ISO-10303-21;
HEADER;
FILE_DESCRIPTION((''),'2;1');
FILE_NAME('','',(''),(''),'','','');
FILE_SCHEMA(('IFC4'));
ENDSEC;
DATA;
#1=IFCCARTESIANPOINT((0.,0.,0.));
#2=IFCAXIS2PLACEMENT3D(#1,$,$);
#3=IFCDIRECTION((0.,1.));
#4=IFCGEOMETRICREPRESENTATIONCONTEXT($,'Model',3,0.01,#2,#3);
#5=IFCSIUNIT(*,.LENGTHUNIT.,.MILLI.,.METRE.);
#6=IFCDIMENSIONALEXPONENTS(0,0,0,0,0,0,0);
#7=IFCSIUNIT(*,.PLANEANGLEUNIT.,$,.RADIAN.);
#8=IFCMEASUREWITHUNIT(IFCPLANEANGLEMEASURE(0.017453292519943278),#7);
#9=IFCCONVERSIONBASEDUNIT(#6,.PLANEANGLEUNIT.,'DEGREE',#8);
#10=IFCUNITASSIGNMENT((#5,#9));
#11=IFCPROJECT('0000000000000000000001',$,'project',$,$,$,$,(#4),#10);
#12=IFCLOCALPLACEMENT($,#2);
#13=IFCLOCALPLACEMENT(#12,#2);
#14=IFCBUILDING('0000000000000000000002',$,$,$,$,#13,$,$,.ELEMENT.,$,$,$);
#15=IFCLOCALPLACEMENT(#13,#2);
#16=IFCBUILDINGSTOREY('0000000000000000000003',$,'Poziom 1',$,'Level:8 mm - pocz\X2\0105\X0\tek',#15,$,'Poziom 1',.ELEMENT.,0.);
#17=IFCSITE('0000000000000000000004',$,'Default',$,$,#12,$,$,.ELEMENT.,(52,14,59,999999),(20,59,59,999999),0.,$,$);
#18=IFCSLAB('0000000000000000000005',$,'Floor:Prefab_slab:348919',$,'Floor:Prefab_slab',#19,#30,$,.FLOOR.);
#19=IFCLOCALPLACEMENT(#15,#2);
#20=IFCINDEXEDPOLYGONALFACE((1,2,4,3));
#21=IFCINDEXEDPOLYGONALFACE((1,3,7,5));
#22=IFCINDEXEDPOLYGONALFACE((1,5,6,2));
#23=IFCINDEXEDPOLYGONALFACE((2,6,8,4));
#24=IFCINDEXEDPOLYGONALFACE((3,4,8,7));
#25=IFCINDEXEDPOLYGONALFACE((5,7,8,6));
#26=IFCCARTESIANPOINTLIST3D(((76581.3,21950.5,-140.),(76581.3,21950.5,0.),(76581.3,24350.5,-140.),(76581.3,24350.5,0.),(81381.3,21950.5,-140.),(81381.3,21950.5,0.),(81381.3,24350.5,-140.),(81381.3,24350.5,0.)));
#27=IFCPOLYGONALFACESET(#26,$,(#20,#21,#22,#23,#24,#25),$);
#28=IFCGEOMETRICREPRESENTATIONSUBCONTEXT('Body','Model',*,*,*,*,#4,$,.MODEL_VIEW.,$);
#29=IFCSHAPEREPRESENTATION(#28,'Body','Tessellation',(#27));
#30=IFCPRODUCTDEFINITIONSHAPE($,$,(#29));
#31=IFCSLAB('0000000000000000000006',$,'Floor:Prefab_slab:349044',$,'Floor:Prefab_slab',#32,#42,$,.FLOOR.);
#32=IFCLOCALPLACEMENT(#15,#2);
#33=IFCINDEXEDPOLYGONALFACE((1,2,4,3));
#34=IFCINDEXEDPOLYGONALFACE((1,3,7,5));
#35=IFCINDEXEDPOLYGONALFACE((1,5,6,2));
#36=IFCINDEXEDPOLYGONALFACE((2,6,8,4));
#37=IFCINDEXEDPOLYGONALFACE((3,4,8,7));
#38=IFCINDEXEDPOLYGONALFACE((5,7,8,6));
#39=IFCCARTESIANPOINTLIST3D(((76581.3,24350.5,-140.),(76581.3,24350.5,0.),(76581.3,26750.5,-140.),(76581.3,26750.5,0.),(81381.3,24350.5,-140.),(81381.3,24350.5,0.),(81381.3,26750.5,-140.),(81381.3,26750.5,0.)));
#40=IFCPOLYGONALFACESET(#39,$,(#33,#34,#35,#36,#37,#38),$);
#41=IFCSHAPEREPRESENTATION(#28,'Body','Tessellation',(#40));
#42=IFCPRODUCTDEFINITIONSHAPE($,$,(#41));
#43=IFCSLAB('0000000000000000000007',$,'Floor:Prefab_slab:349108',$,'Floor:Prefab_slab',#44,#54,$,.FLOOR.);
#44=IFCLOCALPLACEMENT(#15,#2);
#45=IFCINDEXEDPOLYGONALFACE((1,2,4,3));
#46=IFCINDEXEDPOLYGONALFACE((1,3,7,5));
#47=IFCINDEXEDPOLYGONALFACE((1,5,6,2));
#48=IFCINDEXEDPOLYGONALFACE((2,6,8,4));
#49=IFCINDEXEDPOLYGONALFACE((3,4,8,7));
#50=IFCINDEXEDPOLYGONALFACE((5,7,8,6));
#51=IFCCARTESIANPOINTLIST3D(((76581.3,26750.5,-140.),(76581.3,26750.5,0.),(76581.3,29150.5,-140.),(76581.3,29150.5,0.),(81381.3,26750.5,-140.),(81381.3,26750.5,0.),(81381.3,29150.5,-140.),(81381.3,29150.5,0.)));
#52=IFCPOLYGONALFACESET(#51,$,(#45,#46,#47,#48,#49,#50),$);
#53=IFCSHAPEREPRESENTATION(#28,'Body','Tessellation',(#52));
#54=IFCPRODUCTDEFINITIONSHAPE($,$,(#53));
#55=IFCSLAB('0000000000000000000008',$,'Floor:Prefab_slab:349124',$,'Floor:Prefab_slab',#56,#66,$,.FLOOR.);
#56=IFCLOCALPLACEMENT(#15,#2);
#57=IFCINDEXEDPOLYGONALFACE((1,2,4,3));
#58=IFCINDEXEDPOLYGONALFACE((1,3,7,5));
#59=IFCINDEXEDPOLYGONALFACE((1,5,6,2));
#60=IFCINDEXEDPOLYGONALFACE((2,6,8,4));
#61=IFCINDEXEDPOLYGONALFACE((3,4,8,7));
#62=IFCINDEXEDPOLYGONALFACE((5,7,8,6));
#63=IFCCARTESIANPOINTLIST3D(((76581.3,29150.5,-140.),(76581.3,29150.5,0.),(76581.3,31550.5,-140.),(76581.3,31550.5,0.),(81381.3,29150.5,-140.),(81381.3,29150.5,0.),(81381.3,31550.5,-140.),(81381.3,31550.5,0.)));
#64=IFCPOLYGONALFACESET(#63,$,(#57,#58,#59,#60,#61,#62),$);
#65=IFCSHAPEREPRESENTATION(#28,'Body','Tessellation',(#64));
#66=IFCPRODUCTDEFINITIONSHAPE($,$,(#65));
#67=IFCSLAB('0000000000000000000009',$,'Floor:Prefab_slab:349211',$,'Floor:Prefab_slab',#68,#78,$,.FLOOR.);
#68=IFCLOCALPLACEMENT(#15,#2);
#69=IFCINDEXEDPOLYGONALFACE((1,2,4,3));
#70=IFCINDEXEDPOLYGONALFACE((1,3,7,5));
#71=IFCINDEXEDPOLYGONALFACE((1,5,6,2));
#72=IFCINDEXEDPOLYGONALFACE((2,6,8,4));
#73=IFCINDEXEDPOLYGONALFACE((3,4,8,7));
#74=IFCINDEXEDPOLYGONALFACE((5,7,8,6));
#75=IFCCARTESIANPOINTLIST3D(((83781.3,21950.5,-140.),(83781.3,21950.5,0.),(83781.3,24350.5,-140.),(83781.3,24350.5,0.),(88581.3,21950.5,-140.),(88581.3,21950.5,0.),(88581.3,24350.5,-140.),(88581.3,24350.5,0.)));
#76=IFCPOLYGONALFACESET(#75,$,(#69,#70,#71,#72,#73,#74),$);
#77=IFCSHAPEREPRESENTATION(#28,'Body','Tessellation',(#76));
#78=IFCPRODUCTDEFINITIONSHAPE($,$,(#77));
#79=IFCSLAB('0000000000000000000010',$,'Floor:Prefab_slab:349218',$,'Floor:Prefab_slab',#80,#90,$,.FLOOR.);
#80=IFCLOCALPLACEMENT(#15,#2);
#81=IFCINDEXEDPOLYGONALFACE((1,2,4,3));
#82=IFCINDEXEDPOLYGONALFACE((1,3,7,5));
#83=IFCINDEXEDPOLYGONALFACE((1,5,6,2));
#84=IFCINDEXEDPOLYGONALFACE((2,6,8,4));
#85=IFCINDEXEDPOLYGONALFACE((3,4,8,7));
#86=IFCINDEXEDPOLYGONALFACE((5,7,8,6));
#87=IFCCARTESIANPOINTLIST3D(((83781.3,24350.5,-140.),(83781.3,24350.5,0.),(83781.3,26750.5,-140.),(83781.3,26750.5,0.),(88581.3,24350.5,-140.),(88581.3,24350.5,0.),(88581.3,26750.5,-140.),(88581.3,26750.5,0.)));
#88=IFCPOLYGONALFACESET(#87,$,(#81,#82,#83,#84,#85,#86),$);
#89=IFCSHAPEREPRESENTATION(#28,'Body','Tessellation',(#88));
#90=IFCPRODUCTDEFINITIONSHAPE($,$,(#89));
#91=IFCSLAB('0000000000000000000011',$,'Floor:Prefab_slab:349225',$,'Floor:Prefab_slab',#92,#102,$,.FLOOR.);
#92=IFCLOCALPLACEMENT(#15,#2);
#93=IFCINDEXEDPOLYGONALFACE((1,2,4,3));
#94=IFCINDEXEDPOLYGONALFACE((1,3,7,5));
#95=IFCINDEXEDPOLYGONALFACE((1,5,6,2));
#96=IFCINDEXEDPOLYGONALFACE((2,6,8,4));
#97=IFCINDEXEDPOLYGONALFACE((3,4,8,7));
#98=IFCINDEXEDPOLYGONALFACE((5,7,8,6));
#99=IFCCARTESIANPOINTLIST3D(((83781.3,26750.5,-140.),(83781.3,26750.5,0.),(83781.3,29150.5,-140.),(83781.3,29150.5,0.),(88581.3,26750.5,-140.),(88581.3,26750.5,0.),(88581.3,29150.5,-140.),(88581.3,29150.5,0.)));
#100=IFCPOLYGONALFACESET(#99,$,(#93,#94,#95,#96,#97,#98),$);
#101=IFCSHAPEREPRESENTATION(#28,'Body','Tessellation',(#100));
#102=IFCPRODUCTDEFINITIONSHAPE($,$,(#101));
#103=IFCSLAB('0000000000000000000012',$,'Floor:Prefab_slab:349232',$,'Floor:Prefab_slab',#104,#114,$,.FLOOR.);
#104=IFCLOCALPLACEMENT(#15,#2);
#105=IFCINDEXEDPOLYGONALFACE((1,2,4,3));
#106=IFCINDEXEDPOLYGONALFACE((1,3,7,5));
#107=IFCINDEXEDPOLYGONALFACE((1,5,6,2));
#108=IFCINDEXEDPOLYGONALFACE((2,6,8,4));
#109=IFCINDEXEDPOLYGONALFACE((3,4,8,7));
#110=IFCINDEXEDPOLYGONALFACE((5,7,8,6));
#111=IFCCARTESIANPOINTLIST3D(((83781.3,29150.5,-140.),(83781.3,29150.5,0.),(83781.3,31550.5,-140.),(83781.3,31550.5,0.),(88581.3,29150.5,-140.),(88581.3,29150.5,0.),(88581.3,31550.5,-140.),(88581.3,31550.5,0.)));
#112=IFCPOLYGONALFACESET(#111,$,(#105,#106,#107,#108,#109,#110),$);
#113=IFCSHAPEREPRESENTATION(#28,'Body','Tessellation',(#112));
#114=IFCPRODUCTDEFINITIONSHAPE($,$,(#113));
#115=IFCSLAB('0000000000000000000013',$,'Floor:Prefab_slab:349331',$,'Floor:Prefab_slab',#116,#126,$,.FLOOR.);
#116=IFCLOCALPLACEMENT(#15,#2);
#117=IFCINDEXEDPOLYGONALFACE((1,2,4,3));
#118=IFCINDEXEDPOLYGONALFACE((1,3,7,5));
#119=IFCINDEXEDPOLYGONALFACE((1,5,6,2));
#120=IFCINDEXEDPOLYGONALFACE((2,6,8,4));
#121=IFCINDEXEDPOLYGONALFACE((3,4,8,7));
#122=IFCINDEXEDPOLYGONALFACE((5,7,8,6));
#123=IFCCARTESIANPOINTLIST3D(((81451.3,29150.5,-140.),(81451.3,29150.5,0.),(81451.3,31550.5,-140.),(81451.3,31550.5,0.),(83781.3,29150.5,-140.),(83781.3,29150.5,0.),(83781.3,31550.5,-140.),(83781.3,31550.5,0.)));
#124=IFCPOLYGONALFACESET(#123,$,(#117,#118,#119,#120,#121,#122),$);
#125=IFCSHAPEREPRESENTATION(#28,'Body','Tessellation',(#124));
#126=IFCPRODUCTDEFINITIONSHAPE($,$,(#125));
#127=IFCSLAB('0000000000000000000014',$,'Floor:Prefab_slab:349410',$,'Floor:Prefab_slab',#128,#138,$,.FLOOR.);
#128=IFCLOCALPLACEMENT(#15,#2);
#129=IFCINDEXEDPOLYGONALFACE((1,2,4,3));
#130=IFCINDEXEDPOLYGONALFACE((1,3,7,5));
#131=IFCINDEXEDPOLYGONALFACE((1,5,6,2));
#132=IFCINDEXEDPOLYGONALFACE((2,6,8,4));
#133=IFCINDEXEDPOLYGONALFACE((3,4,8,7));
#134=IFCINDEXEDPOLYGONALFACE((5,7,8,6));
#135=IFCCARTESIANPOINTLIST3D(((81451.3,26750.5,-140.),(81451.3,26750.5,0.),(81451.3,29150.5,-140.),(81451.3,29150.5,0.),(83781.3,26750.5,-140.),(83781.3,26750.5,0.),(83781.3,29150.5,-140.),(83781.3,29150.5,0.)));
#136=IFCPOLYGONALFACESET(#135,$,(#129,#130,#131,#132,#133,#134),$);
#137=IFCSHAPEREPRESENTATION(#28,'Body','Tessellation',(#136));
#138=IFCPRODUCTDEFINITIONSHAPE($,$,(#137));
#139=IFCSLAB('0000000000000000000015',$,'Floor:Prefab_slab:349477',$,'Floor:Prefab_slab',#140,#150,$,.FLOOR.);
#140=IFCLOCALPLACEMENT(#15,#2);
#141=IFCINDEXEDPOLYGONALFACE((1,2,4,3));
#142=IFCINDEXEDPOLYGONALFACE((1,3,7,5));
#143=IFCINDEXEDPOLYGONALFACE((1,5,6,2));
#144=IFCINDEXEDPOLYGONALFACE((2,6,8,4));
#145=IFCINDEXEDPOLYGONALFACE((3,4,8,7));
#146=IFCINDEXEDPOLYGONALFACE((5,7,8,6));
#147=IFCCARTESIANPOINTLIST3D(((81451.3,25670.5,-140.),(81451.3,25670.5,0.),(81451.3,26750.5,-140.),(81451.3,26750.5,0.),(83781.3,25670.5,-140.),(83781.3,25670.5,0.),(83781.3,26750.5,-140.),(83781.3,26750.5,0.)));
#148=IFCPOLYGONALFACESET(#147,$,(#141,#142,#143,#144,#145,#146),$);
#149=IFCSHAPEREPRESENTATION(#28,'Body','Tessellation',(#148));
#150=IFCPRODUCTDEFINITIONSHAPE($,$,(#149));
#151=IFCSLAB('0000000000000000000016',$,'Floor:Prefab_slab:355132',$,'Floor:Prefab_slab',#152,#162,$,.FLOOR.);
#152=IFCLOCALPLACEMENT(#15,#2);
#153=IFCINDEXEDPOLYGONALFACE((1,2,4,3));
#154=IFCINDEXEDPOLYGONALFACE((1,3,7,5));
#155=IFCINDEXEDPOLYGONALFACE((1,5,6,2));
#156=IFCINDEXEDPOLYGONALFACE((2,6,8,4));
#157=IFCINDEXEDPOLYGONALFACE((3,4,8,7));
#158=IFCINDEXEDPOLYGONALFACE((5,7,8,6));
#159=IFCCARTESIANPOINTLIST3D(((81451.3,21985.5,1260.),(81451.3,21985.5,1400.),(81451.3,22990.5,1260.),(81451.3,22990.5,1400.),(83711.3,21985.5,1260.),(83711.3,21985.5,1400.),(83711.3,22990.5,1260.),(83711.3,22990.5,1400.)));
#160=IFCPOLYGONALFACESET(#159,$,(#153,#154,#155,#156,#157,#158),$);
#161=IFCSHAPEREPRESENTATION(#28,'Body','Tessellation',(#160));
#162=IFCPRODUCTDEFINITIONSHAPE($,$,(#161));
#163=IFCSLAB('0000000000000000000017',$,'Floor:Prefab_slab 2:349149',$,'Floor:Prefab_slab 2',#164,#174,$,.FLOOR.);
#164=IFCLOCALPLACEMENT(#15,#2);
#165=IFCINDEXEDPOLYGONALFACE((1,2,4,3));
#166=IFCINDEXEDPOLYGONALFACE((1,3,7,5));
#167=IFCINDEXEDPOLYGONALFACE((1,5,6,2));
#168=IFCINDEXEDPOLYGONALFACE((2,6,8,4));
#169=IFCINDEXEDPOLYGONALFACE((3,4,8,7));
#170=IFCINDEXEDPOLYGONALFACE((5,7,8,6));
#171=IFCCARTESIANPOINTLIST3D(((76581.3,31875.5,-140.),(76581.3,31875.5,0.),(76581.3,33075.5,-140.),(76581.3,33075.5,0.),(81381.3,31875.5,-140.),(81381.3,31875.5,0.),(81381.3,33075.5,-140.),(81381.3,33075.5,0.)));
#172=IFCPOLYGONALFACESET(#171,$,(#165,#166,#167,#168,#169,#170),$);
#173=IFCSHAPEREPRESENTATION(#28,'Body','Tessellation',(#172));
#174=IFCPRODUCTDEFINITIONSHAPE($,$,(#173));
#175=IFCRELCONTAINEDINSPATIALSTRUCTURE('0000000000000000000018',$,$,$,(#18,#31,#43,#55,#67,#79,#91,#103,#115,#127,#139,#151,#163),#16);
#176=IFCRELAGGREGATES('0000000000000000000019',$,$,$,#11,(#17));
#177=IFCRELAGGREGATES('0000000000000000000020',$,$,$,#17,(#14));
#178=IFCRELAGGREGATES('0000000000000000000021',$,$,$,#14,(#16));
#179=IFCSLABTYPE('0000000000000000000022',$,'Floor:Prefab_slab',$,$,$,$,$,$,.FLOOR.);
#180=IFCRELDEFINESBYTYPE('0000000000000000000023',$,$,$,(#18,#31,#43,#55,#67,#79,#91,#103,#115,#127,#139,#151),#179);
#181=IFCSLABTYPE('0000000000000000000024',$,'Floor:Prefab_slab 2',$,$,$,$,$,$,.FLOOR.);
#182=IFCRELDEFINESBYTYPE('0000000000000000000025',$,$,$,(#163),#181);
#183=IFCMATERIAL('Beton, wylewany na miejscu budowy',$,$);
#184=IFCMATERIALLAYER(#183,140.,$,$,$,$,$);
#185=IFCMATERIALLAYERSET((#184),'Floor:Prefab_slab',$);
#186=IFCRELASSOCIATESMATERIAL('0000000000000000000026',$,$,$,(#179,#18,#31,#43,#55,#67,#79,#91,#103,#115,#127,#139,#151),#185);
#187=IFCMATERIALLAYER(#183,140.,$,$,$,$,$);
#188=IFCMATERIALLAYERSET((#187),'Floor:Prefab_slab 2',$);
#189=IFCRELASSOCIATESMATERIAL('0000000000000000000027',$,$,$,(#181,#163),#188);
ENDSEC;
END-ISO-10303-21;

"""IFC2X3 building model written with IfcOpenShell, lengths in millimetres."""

from ifc_helpers import new_model, entity, si_unit, converted_unit, direction, frame, frame_2d, origin, origin_2d_with_axis, place, context, subcontext, project, spatial, rectangle, extrude, material, layer, layer_set, layer_usage, type_object, element, save


model = new_model("IFC2X3")

# Units and contexts
model_context = context("Model", 3, precision=0.01, world=origin(), true_north=direction((0.0, 1.0)))
body_context = subcontext(model_context, "Body", "Model", "MODEL_VIEW")
ifc_project = project(units=[si_unit("LENGTHUNIT", "METRE", prefix="MILLI"), converted_unit("PLANEANGLEUNIT", "DEGREE", entity("IfcPlaneAngleMeasure", 0.017453292519943278), si_unit("PLANEANGLEUNIT", "RADIAN"), dimensions=[0, 0, 0, 0, 0, 0, 0])], contexts=[model_context])

# Site, building, storey
site_placement = place(None, origin())
site = spatial("IfcSite", under=ifc_project, at=site_placement, Name="Default", CompositionType="ELEMENT", RefLatitude=(52, 14, 59, 999999), RefLongitude=(20, 59, 59, 999999), RefElevation=0.0)
building_placement = place(site_placement, origin())
building = spatial("IfcBuilding", under=site, at=building_placement, CompositionType="ELEMENT")
storey_placement = place(building_placement, origin())
storey = spatial("IfcBuildingStorey", under=building, at=storey_placement, Name="Poziom 1", ObjectType="Level:8 mm - początek", LongName="Poziom 1", CompositionType="ELEMENT", Elevation=0.0)

# Slabs
ifc_material_1 = material(Name="Beton, wylewany na miejscu budowy")
ifc_layer_1 = layer(ifc_material_1, 140.0)
ifc_layer_set_1 = layer_set([ifc_layer_1], Name="Floor:Prefab_slab")
ifc_layer_usage_1 = layer_usage(ifc_layer_set_1, "AXIS3", "POSITIVE", 0.0)
slab_type_1 = type_object("IfcSlabType", Name="Floor:Prefab_slab", PredefinedType="FLOOR", material=ifc_layer_set_1)
slab_1_placement = place(storey_placement, origin())
element("IfcSlab", 1, at=slab_1_placement, inside=storey, type_object=slab_type_1, material=ifc_layer_usage_1, Name="Floor:Prefab_slab:348919", ObjectType="Floor:Prefab_slab", PredefinedType="FLOOR", context=body_context, shape_type="SweptSolid", body=[
    extrude(rectangle(XDim=2400.0, YDim=4800.0, at=frame_2d((0.0, 0.0), x_axis=(1.0, 0.0))), frame((78981.3, 23150.5, 0.0), z_axis=(0.0, 0.0, -1.0), x_axis=(0.0, 1.0, 0.0)), (0.0, 0.0, 1.0), 140.0),
])
ifc_layer_usage_2 = layer_usage(ifc_layer_set_1, "AXIS3", "POSITIVE", 0.0)
slab_2_placement = place(storey_placement, origin())
element("IfcSlab", 2, at=slab_2_placement, inside=storey, type_object=slab_type_1, material=ifc_layer_usage_2, Name="Floor:Prefab_slab:349044", ObjectType="Floor:Prefab_slab", PredefinedType="FLOOR", context=body_context, shape_type="SweptSolid", body=[
    extrude(rectangle(XDim=2400.0, YDim=4800.0, at=frame_2d((0.0, 0.0), x_axis=(1.0, 0.0))), frame((78981.3, 25550.5, 0.0), z_axis=(0.0, 0.0, -1.0), x_axis=(0.0, 1.0, 0.0)), (0.0, 0.0, 1.0), 140.0),
])
ifc_layer_usage_3 = layer_usage(ifc_layer_set_1, "AXIS3", "POSITIVE", 0.0)
slab_3_placement = place(storey_placement, origin())
element("IfcSlab", 3, at=slab_3_placement, inside=storey, type_object=slab_type_1, material=ifc_layer_usage_3, Name="Floor:Prefab_slab:349108", ObjectType="Floor:Prefab_slab", PredefinedType="FLOOR", context=body_context, shape_type="SweptSolid", body=[
    extrude(rectangle(XDim=2400.0, YDim=4800.0, at=frame_2d((0.0, 0.0), x_axis=(1.0, 0.0))), frame((78981.3, 27950.5, 0.0), z_axis=(0.0, 0.0, -1.0), x_axis=(0.0, 1.0, 0.0)), (0.0, 0.0, 1.0), 140.0),
])
ifc_layer_usage_4 = layer_usage(ifc_layer_set_1, "AXIS3", "POSITIVE", 0.0)
slab_4_placement = place(storey_placement, origin())
element("IfcSlab", 4, at=slab_4_placement, inside=storey, type_object=slab_type_1, material=ifc_layer_usage_4, Name="Floor:Prefab_slab:349124", ObjectType="Floor:Prefab_slab", PredefinedType="FLOOR", context=body_context, shape_type="SweptSolid", body=[
    extrude(rectangle(XDim=2400.0, YDim=4800.0, at=frame_2d((0.0, 0.0), x_axis=(1.0, 0.0))), frame((78981.3, 30350.5, 0.0), z_axis=(0.0, 0.0, -1.0), x_axis=(0.0, 1.0, 0.0)), (0.0, 0.0, 1.0), 140.0),
])
ifc_layer_usage_5 = layer_usage(ifc_layer_set_1, "AXIS3", "POSITIVE", 0.0)
slab_5_placement = place(storey_placement, origin())
element("IfcSlab", 5, at=slab_5_placement, inside=storey, type_object=slab_type_1, material=ifc_layer_usage_5, Name="Floor:Prefab_slab:349211", ObjectType="Floor:Prefab_slab", PredefinedType="FLOOR", context=body_context, shape_type="SweptSolid", body=[
    extrude(rectangle(XDim=2400.0, YDim=4800.0, at=frame_2d((0.0, 0.0), x_axis=(1.0, 0.0))), frame((86181.3, 23150.5, 0.0), z_axis=(0.0, 0.0, -1.0), x_axis=(0.0, 1.0, 0.0)), (0.0, 0.0, 1.0), 140.0),
])
ifc_layer_usage_6 = layer_usage(ifc_layer_set_1, "AXIS3", "POSITIVE", 0.0)
slab_6_placement = place(storey_placement, origin())
element("IfcSlab", 6, at=slab_6_placement, inside=storey, type_object=slab_type_1, material=ifc_layer_usage_6, Name="Floor:Prefab_slab:349218", ObjectType="Floor:Prefab_slab", PredefinedType="FLOOR", context=body_context, shape_type="SweptSolid", body=[
    extrude(rectangle(XDim=2400.0, YDim=4800.0, at=frame_2d((0.0, 0.0), x_axis=(1.0, 0.0))), frame((86181.3, 25550.5, 0.0), z_axis=(0.0, 0.0, -1.0), x_axis=(0.0, 1.0, 0.0)), (0.0, 0.0, 1.0), 140.0),
])
ifc_layer_usage_7 = layer_usage(ifc_layer_set_1, "AXIS3", "POSITIVE", 0.0)
slab_7_placement = place(storey_placement, origin())
element("IfcSlab", 7, at=slab_7_placement, inside=storey, type_object=slab_type_1, material=ifc_layer_usage_7, Name="Floor:Prefab_slab:349225", ObjectType="Floor:Prefab_slab", PredefinedType="FLOOR", context=body_context, shape_type="SweptSolid", body=[
    extrude(rectangle(XDim=2400.0, YDim=4800.0, at=frame_2d((0.0, 0.0), x_axis=(1.0, 0.0))), frame((86181.3, 27950.5, 0.0), z_axis=(0.0, 0.0, -1.0), x_axis=(0.0, 1.0, 0.0)), (0.0, 0.0, 1.0), 140.0),
])
ifc_layer_usage_8 = layer_usage(ifc_layer_set_1, "AXIS3", "POSITIVE", 0.0)
slab_8_placement = place(storey_placement, origin())
element("IfcSlab", 8, at=slab_8_placement, inside=storey, type_object=slab_type_1, material=ifc_layer_usage_8, Name="Floor:Prefab_slab:349232", ObjectType="Floor:Prefab_slab", PredefinedType="FLOOR", context=body_context, shape_type="SweptSolid", body=[
    extrude(rectangle(XDim=2400.0, YDim=4800.0, at=frame_2d((0.0, 0.0), x_axis=(1.0, 0.0))), frame((86181.3, 30350.5, 0.0), z_axis=(0.0, 0.0, -1.0), x_axis=(0.0, 1.0, 0.0)), (0.0, 0.0, 1.0), 140.0),
])
ifc_layer_usage_9 = layer_usage(ifc_layer_set_1, "AXIS3", "POSITIVE", 0.0)
slab_9_placement = place(storey_placement, origin())
element("IfcSlab", 9, at=slab_9_placement, inside=storey, type_object=slab_type_1, material=ifc_layer_usage_9, Name="Floor:Prefab_slab:349331", ObjectType="Floor:Prefab_slab", PredefinedType="FLOOR", context=body_context, shape_type="SweptSolid", body=[
    extrude(rectangle(XDim=2400.0, YDim=2330.0, at=frame_2d((0.0, 0.0), x_axis=(1.0, 0.0))), frame((82616.3, 30350.5, 0.0), z_axis=(0.0, 0.0, -1.0), x_axis=(0.0, 1.0, 0.0)), (0.0, 0.0, 1.0), 140.0),
])
ifc_layer_usage_10 = layer_usage(ifc_layer_set_1, "AXIS3", "POSITIVE", 0.0)
slab_10_placement = place(storey_placement, origin())
element("IfcSlab", 10, at=slab_10_placement, inside=storey, type_object=slab_type_1, material=ifc_layer_usage_10, Name="Floor:Prefab_slab:349410", ObjectType="Floor:Prefab_slab", PredefinedType="FLOOR", context=body_context, shape_type="SweptSolid", body=[
    extrude(rectangle(XDim=2400.0, YDim=2330.0, at=frame_2d((0.0, 0.0), x_axis=(1.0, 0.0))), frame((82616.3, 27950.5, 0.0), z_axis=(0.0, 0.0, -1.0), x_axis=(0.0, 1.0, 0.0)), (0.0, 0.0, 1.0), 140.0),
])
ifc_layer_usage_11 = layer_usage(ifc_layer_set_1, "AXIS3", "POSITIVE", 0.0)
slab_11_placement = place(storey_placement, origin())
element("IfcSlab", 11, at=slab_11_placement, inside=storey, type_object=slab_type_1, material=ifc_layer_usage_11, Name="Floor:Prefab_slab:349477", ObjectType="Floor:Prefab_slab", PredefinedType="FLOOR", context=body_context, shape_type="SweptSolid", body=[
    extrude(rectangle(XDim=1080.0, YDim=2330.0, at=frame_2d((0.0, 0.0), x_axis=(1.0, 0.0))), frame((82616.3, 26210.5, 0.0), z_axis=(0.0, 0.0, -1.0), x_axis=(0.0, 1.0, 0.0)), (0.0, 0.0, 1.0), 140.0),
])
ifc_layer_usage_12 = layer_usage(ifc_layer_set_1, "AXIS3", "POSITIVE", 0.0)
slab_12_placement = place(storey_placement, origin())
element("IfcSlab", 12, at=slab_12_placement, inside=storey, type_object=slab_type_1, material=ifc_layer_usage_12, Name="Floor:Prefab_slab:355132", ObjectType="Floor:Prefab_slab", PredefinedType="FLOOR", context=body_context, shape_type="SweptSolid", body=[
    extrude(rectangle(XDim=1005.0, YDim=2260.0, at=origin_2d_with_axis()), frame((82581.3, 22488.0, 1400.0), z_axis=(0.0, 0.0, -1.0), x_axis=(0.0, 1.0, 0.0)), (0.0, 0.0, 1.0), 140.0),
])
ifc_layer_2 = layer(ifc_material_1, 140.0)
ifc_layer_set_2 = layer_set([ifc_layer_2], Name="Floor:Prefab_slab 2")
ifc_layer_usage_13 = layer_usage(ifc_layer_set_2, "AXIS3", "POSITIVE", 0.0)
slab_type_2 = type_object("IfcSlabType", Name="Floor:Prefab_slab 2", PredefinedType="FLOOR", material=ifc_layer_set_2)
slab_13_placement = place(storey_placement, origin())
element("IfcSlab", 13, at=slab_13_placement, inside=storey, type_object=slab_type_2, material=ifc_layer_usage_13, Name="Floor:Prefab_slab 2:349149", ObjectType="Floor:Prefab_slab 2", PredefinedType="FLOOR", context=body_context, shape_type="SweptSolid", body=[
    extrude(rectangle(XDim=1200.0, YDim=4800.0, at=frame_2d((0.0, 0.0), x_axis=(1.0, 0.0))), frame((78981.3, 32475.5, 0.0), z_axis=(0.0, 0.0, -1.0), x_axis=(0.0, 1.0, 0.0)), (0.0, 0.0, 1.0), 140.0),
])

save(model, "model.ifc")
